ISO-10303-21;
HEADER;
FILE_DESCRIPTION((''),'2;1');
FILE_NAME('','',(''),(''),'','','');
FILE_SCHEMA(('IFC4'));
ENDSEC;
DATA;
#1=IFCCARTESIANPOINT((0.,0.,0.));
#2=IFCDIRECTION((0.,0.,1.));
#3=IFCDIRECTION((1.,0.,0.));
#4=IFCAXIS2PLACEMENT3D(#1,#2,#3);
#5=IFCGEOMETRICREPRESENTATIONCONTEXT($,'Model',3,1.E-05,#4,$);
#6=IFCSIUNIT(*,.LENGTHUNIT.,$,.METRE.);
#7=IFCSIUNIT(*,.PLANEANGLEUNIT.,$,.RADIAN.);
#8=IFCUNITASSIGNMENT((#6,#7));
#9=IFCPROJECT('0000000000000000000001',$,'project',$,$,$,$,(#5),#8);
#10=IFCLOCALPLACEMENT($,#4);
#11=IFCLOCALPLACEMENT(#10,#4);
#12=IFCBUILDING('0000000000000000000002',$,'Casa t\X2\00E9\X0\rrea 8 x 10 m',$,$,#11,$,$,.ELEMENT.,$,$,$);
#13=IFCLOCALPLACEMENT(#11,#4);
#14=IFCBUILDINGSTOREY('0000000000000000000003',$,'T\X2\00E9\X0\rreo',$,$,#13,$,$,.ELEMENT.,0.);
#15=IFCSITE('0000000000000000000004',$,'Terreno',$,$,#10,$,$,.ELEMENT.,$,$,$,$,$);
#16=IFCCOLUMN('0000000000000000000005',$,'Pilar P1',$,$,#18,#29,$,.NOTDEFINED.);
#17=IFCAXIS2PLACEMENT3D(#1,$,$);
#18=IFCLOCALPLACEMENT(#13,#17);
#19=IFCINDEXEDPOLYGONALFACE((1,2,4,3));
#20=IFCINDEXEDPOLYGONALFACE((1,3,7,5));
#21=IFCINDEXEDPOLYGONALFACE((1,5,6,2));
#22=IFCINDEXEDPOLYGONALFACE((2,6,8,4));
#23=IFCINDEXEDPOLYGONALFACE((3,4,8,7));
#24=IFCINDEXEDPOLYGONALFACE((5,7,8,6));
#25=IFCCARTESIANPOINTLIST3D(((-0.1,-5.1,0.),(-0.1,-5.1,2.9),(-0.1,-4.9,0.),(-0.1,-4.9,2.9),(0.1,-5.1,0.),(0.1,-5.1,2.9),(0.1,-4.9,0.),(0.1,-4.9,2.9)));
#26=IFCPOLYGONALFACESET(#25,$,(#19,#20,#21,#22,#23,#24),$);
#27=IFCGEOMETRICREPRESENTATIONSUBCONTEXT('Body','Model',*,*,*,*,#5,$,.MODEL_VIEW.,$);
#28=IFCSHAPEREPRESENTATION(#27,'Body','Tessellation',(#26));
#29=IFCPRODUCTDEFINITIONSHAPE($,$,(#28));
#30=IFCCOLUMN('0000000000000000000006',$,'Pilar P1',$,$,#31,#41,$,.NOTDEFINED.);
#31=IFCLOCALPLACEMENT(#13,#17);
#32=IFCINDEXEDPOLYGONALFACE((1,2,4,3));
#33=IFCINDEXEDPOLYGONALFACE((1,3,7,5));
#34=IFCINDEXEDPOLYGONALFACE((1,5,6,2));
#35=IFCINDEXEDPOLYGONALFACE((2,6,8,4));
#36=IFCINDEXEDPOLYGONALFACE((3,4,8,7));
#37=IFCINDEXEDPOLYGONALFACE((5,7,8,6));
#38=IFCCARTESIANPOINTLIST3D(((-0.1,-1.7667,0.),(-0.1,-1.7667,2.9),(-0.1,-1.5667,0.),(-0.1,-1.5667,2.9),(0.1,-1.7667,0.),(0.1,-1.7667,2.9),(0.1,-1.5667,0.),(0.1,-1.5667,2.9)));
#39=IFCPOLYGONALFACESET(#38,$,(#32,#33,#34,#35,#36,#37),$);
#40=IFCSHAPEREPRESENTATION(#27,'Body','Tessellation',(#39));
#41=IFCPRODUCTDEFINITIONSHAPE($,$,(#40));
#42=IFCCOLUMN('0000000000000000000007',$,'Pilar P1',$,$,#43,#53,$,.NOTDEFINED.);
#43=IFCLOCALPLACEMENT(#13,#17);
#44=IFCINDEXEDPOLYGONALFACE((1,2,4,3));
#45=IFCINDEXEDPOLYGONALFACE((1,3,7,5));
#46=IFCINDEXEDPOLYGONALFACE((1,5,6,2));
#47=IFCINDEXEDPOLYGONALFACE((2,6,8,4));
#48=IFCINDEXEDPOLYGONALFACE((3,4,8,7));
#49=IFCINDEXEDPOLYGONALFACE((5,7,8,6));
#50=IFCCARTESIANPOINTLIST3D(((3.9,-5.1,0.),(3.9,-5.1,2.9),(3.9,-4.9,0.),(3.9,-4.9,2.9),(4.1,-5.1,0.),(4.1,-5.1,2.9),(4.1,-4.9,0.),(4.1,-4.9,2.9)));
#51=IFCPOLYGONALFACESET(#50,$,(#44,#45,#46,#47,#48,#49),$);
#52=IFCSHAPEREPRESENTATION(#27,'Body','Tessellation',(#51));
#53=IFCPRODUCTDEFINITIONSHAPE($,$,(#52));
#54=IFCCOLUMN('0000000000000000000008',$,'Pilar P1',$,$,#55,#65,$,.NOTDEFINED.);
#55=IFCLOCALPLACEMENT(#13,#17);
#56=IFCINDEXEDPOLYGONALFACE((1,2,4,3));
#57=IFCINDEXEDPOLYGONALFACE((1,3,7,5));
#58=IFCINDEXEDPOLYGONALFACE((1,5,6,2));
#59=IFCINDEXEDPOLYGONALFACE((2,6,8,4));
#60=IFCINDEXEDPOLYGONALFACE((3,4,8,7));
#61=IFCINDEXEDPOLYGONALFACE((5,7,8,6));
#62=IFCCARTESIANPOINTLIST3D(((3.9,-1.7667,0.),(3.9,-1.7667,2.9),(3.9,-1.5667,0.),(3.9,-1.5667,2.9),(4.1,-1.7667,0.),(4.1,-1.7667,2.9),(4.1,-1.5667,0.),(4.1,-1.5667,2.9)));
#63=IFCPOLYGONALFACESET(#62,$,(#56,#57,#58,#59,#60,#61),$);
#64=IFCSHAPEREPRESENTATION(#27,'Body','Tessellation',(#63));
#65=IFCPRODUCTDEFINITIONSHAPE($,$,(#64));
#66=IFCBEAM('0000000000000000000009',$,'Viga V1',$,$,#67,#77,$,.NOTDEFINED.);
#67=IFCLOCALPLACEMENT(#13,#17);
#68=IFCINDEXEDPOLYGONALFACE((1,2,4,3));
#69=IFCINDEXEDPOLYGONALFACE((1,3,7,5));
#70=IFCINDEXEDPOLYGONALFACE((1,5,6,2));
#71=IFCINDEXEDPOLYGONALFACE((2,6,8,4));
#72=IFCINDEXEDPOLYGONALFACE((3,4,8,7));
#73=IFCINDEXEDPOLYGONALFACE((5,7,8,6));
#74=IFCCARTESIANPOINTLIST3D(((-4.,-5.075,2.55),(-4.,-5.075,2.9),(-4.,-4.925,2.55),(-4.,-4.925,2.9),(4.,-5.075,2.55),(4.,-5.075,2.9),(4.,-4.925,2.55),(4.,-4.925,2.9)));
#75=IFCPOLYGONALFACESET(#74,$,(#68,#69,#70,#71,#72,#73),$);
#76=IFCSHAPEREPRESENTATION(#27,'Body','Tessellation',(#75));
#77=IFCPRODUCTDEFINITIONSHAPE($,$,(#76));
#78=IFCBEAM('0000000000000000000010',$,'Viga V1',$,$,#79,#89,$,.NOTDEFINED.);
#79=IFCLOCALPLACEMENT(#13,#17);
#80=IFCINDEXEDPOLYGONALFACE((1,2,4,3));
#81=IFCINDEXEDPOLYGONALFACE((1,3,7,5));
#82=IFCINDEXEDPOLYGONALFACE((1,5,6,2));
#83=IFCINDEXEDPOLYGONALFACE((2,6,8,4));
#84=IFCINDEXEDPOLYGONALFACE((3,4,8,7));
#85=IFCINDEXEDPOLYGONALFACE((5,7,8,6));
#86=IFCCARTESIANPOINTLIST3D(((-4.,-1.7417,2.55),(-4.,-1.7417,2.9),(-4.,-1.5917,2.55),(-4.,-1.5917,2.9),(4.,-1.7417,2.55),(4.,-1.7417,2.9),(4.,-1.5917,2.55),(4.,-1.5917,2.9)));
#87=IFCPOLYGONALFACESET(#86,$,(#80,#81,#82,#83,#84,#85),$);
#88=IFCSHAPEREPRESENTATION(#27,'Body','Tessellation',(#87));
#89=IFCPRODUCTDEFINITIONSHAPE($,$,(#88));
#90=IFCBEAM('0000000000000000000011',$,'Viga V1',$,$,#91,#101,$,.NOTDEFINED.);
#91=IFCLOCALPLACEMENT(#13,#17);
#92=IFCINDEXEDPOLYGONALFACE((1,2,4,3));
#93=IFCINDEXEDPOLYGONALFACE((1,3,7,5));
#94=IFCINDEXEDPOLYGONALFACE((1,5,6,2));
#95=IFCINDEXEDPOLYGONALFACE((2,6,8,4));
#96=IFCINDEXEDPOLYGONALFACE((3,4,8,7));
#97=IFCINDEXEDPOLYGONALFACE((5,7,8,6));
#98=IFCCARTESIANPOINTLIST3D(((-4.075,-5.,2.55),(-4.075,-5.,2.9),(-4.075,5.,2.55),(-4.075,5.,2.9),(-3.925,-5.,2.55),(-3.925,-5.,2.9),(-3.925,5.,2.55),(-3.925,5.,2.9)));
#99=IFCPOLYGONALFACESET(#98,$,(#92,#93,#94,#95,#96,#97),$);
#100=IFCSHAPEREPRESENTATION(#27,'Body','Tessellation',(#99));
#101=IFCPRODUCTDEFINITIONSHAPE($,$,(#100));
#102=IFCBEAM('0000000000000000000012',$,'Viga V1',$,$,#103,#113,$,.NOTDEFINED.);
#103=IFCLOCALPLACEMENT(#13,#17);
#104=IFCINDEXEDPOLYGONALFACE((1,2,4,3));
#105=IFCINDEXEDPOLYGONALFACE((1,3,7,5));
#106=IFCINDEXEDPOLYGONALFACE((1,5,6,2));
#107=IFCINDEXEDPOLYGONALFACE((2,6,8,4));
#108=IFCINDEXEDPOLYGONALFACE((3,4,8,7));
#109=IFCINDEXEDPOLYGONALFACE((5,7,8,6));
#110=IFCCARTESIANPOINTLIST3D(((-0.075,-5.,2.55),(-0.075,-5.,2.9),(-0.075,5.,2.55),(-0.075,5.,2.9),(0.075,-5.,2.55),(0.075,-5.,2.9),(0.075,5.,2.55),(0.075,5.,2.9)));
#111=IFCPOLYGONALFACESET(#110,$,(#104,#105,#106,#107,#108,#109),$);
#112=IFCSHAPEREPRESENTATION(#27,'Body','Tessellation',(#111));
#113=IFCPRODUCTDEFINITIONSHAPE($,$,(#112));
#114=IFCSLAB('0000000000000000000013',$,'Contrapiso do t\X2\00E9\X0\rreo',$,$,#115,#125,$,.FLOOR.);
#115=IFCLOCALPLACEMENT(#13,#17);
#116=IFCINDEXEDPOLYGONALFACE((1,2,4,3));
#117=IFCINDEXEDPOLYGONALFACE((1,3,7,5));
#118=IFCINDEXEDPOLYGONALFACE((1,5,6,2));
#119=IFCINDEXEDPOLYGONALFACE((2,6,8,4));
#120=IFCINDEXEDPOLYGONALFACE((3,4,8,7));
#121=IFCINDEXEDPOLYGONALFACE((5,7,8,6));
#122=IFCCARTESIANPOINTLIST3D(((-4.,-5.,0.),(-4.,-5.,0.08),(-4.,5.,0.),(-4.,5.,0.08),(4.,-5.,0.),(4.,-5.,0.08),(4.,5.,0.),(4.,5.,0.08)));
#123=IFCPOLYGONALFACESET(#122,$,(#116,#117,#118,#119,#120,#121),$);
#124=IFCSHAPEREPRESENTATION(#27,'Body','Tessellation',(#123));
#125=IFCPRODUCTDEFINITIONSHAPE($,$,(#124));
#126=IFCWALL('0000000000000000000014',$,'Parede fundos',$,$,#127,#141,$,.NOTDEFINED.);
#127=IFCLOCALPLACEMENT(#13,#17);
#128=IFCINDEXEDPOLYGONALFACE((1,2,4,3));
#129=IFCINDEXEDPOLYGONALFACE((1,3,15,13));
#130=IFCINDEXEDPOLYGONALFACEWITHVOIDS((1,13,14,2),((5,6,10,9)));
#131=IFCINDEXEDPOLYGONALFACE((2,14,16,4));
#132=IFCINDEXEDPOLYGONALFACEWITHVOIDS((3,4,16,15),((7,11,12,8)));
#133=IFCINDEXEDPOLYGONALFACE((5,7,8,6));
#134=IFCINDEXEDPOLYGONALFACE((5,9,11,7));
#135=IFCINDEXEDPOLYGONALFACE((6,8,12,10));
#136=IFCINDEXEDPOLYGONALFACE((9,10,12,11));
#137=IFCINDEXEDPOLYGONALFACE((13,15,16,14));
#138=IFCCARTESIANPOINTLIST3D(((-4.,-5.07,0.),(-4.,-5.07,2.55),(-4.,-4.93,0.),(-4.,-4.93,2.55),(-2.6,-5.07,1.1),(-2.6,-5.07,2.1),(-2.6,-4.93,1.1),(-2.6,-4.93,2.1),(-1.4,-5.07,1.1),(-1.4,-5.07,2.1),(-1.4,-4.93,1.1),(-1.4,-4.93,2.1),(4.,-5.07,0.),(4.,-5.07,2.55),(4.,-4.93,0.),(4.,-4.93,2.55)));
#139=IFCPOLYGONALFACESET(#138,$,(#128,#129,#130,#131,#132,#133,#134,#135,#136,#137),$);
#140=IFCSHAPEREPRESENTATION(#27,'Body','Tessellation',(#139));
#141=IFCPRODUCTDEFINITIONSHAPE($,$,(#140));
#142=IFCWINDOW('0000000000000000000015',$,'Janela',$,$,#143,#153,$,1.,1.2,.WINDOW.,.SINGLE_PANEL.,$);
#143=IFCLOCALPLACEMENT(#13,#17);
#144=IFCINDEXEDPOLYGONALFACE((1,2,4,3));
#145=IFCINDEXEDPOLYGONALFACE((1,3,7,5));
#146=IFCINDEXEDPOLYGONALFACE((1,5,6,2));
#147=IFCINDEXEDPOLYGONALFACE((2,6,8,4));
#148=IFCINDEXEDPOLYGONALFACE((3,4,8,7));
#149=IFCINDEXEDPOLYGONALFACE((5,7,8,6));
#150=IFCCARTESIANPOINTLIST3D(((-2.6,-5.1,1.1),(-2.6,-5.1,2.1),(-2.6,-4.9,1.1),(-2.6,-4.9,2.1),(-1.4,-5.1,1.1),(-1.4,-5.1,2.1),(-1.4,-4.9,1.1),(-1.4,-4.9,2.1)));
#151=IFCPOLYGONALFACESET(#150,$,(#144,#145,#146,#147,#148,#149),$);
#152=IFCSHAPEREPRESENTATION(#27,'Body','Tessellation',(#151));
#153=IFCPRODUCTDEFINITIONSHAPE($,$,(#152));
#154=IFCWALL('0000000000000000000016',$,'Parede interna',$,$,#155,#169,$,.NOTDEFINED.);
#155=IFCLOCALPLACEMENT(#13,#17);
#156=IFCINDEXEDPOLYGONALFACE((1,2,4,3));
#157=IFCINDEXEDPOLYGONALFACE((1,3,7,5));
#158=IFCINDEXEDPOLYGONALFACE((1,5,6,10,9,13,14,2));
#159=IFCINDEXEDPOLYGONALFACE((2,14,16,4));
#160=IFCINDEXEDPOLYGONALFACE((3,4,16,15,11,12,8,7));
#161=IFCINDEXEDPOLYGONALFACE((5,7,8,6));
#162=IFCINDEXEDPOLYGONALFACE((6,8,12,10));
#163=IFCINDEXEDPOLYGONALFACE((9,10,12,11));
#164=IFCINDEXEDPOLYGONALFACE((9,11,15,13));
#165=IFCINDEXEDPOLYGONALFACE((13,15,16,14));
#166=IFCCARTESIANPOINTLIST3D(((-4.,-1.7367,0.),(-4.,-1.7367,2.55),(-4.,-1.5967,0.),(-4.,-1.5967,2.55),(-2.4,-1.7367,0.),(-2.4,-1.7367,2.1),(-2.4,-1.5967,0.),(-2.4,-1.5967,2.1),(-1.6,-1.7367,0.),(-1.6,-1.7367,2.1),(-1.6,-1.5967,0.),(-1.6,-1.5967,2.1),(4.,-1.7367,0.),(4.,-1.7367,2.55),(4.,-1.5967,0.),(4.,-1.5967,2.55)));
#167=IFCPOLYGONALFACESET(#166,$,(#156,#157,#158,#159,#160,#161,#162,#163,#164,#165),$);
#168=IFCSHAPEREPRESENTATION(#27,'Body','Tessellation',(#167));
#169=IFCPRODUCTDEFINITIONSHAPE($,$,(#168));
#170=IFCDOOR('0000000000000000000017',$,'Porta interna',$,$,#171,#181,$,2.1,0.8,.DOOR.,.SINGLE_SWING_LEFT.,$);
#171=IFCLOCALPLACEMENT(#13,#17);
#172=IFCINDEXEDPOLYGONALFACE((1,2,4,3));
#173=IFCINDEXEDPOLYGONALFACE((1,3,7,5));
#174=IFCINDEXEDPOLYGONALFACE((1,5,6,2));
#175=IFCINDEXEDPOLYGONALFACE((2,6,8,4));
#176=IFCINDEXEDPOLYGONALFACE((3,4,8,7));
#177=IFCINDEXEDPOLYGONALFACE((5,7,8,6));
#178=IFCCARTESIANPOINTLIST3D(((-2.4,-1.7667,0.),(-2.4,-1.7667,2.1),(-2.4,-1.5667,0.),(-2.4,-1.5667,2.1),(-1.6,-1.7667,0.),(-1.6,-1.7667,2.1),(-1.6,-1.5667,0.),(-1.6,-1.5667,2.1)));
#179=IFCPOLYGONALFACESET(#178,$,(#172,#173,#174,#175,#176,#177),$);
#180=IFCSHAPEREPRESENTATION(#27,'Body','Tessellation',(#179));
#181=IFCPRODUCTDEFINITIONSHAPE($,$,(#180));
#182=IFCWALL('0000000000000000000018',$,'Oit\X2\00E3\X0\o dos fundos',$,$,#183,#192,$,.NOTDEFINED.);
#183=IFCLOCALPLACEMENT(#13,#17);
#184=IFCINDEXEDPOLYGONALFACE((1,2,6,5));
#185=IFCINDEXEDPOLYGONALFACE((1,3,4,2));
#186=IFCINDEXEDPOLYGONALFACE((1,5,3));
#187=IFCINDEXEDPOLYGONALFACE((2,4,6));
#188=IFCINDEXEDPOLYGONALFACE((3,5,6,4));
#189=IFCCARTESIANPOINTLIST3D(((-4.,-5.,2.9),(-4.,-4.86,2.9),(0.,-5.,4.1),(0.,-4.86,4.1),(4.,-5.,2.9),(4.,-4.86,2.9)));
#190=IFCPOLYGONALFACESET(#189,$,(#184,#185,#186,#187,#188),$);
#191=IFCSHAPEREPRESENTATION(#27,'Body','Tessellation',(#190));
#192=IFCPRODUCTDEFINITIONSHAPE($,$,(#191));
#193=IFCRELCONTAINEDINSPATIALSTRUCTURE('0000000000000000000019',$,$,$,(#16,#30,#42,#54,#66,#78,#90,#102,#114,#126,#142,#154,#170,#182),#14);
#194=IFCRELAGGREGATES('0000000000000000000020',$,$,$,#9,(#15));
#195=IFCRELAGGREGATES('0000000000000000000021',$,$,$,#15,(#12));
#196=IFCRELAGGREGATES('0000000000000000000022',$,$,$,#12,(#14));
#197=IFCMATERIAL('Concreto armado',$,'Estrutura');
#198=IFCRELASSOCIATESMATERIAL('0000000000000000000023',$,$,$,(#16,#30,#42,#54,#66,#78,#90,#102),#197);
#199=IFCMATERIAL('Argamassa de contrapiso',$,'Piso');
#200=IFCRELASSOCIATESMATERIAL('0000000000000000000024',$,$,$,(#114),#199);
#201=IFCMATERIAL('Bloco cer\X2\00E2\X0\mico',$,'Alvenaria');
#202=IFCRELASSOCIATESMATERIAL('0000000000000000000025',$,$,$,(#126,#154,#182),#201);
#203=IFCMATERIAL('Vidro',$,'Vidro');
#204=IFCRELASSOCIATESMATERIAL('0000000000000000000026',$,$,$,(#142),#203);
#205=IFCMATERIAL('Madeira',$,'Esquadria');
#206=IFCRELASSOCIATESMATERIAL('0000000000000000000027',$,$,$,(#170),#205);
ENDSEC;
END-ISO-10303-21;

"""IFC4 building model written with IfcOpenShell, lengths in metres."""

from ifc_helpers import new_model, si_unit, frame, origin_with_axes, origin_2d, place, context, subcontext, project, spatial, polyline, rectangle, outline, extrude, material, element, fill, save


model = new_model("IFC4")

# Units and contexts
model_context = context("Model", 3, precision=1e-05, world=origin_with_axes())
body_context = subcontext(model_context, "Body", "Model", "MODEL_VIEW")
ifc_project = project(units=[si_unit("LENGTHUNIT", "METRE"), si_unit("PLANEANGLEUNIT", "RADIAN")], contexts=[model_context])

# Site, building, storey
site_placement = place(None, origin_with_axes())
site = spatial("IfcSite", under=ifc_project, at=site_placement, Name="Terreno", CompositionType="ELEMENT")
building_placement = place(site_placement, origin_with_axes())
building = spatial("IfcBuilding", under=site, at=building_placement, Name="Casa térrea 8 x 10 m", CompositionType="ELEMENT")
storey_placement = place(building_placement, origin_with_axes())
storey = spatial("IfcBuildingStorey", under=building, at=storey_placement, Name="Térreo", CompositionType="ELEMENT", Elevation=0.0)

# Shared definitions
ifc_material_1 = material(Name="Concreto armado", Category="Estrutura")

# Columns
for number, where, z_axis, x_axis, name in (
    (1, (0.0, -5.0, 0.0), (0.0, 0.0, 1.0), (1.0, 0.0, 0.0), "Pilar P1"),
    (2, (0.0, -1.6667, 0.0), (0.0, 0.0, 1.0), (1.0, 0.0, 0.0), "Pilar P1"),
    (3, (4.0, -5.0, 0.0), (0.0, 0.0, 1.0), (1.0, 0.0, 0.0), "Pilar P1"),
    (4, (4.0, -1.6667, 0.0), (0.0, 0.0, 1.0), (1.0, 0.0, 0.0), "Pilar P1"),
):
    element("IfcColumn", number, at=place(storey_placement, frame(where, z_axis=z_axis, x_axis=x_axis)), inside=storey, material=ifc_material_1, Name=name, PredefinedType="NOTDEFINED", context=body_context, shape_type="SweptSolid", body=[
        extrude(rectangle(XDim=0.2, YDim=0.2, at=origin_2d()), None, (0.0, 0.0, 1.0), 2.9),
    ])

# Beams
for number, where, z_axis, x_axis, name in (
    (5, (0.0, -5.0, 2.55), (0.0, 0.0, 1.0), (1.0, 0.0, 0.0), "Viga V1"),
    (6, (0.0, -1.6667, 2.55), (0.0, 0.0, 1.0), (1.0, 0.0, 0.0), "Viga V1"),
):
    element("IfcBeam", number, at=place(storey_placement, frame(where, z_axis=z_axis, x_axis=x_axis)), inside=storey, material=ifc_material_1, Name=name, PredefinedType="NOTDEFINED", context=body_context, shape_type="SweptSolid", body=[
        extrude(rectangle(XDim=8.0, YDim=0.15, at=origin_2d()), None, (0.0, 0.0, 1.0), 0.35),
    ])
for number, where, z_axis, x_axis, name in (
    (7, (-4.0, 0.0, 2.55), (0.0, 0.0, 1.0), (1.0, 0.0, 0.0), "Viga V1"),
    (8, (0.0, 0.0, 2.55), (0.0, 0.0, 1.0), (1.0, 0.0, 0.0), "Viga V1"),
):
    element("IfcBeam", number, at=place(storey_placement, frame(where, z_axis=z_axis, x_axis=x_axis)), inside=storey, material=ifc_material_1, Name=name, PredefinedType="NOTDEFINED", context=body_context, shape_type="SweptSolid", body=[
        extrude(rectangle(XDim=0.15, YDim=10.0, at=origin_2d()), None, (0.0, 0.0, 1.0), 0.35),
    ])

# Slab
ifc_material_2 = material(Name="Argamassa de contrapiso", Category="Piso")
slab_placement = place(storey_placement, origin_with_axes())
element("IfcSlab", 9, at=slab_placement, inside=storey, material=ifc_material_2, Name="Contrapiso do térreo", PredefinedType="FLOOR", context=body_context, shape_type="SweptSolid", body=[
    extrude(rectangle(XDim=8.0, YDim=10.0, at=origin_2d()), None, (0.0, 0.0, 1.0), 0.08),
])

# Wall, opening, window
ifc_material_3 = material(Name="Bloco cerâmico", Category="Alvenaria")
wall_1_placement = place(storey_placement, frame((0.0, -5.0, 0.0), z_axis=(0.0, 0.0, 1.0), x_axis=(1.0, 0.0, 0.0)))
wall_1 = element("IfcWall", 10, at=wall_1_placement, inside=storey, material=ifc_material_3, Name="Parede fundos", PredefinedType="NOTDEFINED", context=body_context, shape_type="SweptSolid", body=[
    extrude(rectangle(XDim=8.0, YDim=0.14, at=origin_2d()), None, (0.0, 0.0, 1.0), 2.55),
])
opening_1_placement = place(storey_placement, frame((-2.0, -5.0, 1.1), z_axis=(0.0, 0.0, 1.0), x_axis=(1.0, 0.0, 0.0)))
opening_1 = element("IfcOpeningElement", 11, at=opening_1_placement, cuts=wall_1, PredefinedType="OPENING", context=body_context, shape_type="SweptSolid", body=[
    extrude(rectangle(XDim=1.2, YDim=0.4, at=origin_2d()), None, (0.0, 0.0, 1.0), 1.0),
])
ifc_material_4 = material(Name="Vidro", Category="Vidro")
window_placement = place(storey_placement, frame((-2.0, -5.0, 1.1), z_axis=(0.0, 0.0, 1.0), x_axis=(1.0, 0.0, 0.0)))
window = element("IfcWindow", 12, at=window_placement, inside=storey, material=ifc_material_4, Name="Janela", OverallHeight=1.0, OverallWidth=1.2, PartitioningType="SINGLE_PANEL", PredefinedType="WINDOW", context=body_context, shape_type="SweptSolid", body=[
    extrude(rectangle(XDim=1.2, YDim=0.2, at=origin_2d()), None, (0.0, 0.0, 1.0), 1.0),
])
fill(opening_1, window)

# Wall, opening, door
wall_2_placement = place(storey_placement, frame((0.0, -1.6667, 0.0), z_axis=(0.0, 0.0, 1.0), x_axis=(1.0, 0.0, 0.0)))
wall_2 = element("IfcWall", 13, at=wall_2_placement, inside=storey, material=ifc_material_3, Name="Parede interna", PredefinedType="NOTDEFINED", context=body_context, shape_type="SweptSolid", body=[
    extrude(rectangle(XDim=8.0, YDim=0.14, at=origin_2d()), None, (0.0, 0.0, 1.0), 2.55),
])
opening_2_placement = place(storey_placement, frame((-2.0, -1.6667, 0.0), z_axis=(0.0, 0.0, 1.0), x_axis=(1.0, 0.0, 0.0)))
opening_2 = element("IfcOpeningElement", 14, at=opening_2_placement, cuts=wall_2, PredefinedType="OPENING", context=body_context, shape_type="SweptSolid", body=[
    extrude(rectangle(XDim=0.8, YDim=0.4, at=origin_2d()), None, (0.0, 0.0, 1.0), 2.1),
])
ifc_material_5 = material(Name="Madeira", Category="Esquadria")
door_placement = place(storey_placement, frame((-2.0, -1.6667, 0.0), z_axis=(0.0, 0.0, 1.0), x_axis=(1.0, 0.0, 0.0)))
door = element("IfcDoor", 15, at=door_placement, inside=storey, material=ifc_material_5, Name="Porta interna", OperationType="SINGLE_SWING_LEFT", OverallHeight=2.1, OverallWidth=0.8, PredefinedType="DOOR", context=body_context, shape_type="SweptSolid", body=[
    extrude(rectangle(XDim=0.8, YDim=0.2, at=origin_2d()), None, (0.0, 0.0, 1.0), 2.1),
])
fill(opening_2, door)

# Wall
wall_3_placement = place(storey_placement, frame((0.0, -4.86, 2.9), z_axis=(0.0, -1.0, 0.0), x_axis=(1.0, 0.0, 0.0)))
element("IfcWall", 16, at=wall_3_placement, inside=storey, material=ifc_material_3, Name="Oitão dos fundos", PredefinedType="NOTDEFINED", context=body_context, shape_type="SweptSolid", body=[
    extrude(outline(polyline([(-4.0, 0.0), (4.0, 0.0), (0.0, 1.2), (-4.0, 0.0)])), None, (0.0, 0.0, 1.0), 0.14),
])

save(model, "model.ifc")
